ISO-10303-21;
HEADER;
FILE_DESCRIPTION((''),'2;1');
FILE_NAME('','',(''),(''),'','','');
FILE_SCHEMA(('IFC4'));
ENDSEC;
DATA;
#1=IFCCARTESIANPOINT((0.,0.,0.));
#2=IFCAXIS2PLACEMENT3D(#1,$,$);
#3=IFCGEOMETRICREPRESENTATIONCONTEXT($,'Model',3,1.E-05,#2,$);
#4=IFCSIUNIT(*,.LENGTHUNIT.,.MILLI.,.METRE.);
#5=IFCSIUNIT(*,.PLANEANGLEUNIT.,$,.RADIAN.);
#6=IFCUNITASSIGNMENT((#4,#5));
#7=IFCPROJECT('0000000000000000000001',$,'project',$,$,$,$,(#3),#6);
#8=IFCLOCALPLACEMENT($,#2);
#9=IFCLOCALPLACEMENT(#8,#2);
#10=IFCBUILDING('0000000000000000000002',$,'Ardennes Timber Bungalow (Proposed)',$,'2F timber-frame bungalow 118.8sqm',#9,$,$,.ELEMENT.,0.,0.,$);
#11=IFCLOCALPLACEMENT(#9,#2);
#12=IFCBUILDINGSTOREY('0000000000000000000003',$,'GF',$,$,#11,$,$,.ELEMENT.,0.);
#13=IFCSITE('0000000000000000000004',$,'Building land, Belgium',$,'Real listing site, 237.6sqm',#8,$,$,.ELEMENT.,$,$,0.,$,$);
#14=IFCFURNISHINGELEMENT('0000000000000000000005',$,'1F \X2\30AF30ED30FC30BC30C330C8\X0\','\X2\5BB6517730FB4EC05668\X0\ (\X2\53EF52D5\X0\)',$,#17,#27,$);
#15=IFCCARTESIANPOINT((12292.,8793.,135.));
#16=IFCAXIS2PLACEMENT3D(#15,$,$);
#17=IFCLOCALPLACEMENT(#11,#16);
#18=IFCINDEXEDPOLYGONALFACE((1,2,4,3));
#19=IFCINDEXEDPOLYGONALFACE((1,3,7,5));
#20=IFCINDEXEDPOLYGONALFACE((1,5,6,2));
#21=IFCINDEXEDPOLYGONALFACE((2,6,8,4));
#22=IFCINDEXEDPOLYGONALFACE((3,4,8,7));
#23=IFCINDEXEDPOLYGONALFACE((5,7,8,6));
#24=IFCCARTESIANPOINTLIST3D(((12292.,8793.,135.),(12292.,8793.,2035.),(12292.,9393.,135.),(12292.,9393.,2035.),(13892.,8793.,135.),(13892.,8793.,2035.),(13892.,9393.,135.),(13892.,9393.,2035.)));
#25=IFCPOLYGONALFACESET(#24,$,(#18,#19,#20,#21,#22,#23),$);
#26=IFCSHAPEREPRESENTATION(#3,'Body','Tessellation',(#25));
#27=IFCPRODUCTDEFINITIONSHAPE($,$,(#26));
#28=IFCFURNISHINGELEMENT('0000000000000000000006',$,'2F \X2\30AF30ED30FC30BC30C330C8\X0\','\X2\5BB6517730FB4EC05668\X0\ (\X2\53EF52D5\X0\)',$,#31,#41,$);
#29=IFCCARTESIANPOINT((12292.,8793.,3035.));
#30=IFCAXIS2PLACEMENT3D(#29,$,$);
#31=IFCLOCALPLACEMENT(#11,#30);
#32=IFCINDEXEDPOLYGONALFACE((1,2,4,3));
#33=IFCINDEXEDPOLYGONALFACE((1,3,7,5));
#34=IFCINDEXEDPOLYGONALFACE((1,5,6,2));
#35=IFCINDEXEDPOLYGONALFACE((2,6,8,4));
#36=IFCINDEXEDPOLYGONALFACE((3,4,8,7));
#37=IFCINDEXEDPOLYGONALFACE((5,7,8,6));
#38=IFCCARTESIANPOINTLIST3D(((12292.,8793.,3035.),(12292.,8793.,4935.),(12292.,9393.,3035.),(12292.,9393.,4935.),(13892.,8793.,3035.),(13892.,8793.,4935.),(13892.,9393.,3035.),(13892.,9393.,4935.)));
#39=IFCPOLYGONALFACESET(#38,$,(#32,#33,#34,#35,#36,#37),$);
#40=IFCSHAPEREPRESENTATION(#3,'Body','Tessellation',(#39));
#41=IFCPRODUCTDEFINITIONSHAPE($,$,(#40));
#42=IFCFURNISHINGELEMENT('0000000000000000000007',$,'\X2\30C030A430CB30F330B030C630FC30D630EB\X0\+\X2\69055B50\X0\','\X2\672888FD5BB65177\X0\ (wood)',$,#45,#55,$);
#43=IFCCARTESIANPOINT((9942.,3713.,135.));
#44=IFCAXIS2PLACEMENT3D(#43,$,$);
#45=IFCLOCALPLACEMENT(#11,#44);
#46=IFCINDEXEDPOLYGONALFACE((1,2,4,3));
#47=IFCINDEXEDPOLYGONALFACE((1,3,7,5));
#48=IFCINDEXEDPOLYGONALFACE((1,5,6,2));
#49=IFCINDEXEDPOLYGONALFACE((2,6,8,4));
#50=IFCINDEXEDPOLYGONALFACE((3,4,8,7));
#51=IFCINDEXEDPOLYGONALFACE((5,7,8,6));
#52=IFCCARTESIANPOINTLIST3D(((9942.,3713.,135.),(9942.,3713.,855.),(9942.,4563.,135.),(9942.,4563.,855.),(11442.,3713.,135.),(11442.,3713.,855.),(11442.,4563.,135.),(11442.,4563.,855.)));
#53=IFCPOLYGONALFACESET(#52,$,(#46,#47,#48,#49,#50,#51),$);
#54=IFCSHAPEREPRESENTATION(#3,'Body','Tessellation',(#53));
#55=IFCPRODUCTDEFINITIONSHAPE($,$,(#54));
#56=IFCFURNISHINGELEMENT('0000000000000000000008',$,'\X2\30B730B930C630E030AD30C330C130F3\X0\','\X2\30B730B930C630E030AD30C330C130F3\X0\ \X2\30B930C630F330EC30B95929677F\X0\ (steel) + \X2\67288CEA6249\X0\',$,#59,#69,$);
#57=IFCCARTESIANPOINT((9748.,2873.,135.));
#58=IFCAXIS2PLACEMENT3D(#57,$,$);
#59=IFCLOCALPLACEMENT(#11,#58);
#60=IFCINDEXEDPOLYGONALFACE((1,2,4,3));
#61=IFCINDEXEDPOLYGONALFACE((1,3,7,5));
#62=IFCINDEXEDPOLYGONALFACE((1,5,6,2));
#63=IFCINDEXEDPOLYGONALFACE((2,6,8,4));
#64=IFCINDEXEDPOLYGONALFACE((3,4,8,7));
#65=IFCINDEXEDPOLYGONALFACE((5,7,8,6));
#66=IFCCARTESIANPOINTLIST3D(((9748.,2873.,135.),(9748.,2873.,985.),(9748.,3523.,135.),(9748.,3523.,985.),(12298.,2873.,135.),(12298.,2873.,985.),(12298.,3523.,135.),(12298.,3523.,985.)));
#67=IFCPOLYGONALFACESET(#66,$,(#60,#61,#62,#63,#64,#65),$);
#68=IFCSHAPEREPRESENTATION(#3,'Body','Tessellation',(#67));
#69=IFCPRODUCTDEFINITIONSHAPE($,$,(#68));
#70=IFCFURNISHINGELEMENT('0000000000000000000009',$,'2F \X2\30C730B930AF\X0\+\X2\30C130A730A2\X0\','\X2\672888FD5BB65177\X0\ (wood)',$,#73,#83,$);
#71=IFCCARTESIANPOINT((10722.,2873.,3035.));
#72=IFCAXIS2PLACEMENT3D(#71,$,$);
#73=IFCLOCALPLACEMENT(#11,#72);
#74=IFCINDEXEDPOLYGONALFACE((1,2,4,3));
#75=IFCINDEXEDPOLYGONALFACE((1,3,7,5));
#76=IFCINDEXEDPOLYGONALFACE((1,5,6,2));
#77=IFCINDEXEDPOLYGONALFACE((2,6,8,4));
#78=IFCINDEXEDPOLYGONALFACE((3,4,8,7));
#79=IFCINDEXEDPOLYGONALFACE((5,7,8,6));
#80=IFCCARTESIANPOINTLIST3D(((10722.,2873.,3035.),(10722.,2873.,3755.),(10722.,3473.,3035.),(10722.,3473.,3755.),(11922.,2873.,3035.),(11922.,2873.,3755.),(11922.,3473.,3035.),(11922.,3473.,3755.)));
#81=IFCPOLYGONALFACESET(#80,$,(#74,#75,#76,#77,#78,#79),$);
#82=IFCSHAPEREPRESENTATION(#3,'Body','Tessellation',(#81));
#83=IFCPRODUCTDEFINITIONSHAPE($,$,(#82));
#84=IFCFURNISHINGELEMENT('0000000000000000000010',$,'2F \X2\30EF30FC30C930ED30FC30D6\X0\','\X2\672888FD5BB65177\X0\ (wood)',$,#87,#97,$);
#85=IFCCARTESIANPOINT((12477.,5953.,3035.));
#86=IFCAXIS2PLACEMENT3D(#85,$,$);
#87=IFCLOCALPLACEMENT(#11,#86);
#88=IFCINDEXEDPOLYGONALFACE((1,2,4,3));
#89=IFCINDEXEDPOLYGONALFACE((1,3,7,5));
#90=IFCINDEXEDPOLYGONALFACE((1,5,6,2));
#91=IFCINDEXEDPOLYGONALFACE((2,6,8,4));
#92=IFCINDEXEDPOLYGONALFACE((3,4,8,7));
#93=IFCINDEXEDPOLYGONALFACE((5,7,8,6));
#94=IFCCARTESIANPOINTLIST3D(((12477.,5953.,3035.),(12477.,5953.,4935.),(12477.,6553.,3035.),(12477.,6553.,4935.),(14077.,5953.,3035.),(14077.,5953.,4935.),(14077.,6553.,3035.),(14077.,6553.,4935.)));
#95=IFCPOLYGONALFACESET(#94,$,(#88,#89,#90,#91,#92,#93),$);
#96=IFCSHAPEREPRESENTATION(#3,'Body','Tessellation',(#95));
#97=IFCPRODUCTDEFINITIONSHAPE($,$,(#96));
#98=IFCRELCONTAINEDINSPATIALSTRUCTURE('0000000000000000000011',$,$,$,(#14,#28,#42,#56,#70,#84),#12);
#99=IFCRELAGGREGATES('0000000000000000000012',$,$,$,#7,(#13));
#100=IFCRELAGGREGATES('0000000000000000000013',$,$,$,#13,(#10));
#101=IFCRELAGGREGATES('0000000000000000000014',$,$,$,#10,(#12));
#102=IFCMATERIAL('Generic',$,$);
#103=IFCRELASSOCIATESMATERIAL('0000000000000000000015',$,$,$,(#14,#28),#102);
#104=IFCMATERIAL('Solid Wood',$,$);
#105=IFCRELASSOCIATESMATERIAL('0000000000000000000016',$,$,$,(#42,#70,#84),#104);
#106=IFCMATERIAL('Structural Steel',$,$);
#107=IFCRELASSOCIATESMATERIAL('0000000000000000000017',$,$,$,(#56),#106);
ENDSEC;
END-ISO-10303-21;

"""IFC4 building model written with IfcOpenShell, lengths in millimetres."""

from ifc_helpers import new_model, si_unit, frame, frame_2d, origin, place, context, project, spatial, rectangle, extrude, material, element, save


model = new_model("IFC4")

# Units and contexts
model_context = context("Model", 3, precision=1e-05, world=origin())
ifc_project = project(units=[si_unit("LENGTHUNIT", "METRE", prefix="MILLI"), si_unit("PLANEANGLEUNIT", "RADIAN")], contexts=[model_context])

# Site, building, storey
site_placement = place(None, origin())
site = spatial("IfcSite", under=ifc_project, at=site_placement, Name="Building land, Belgium", ObjectType="Real listing site, 237.6sqm", CompositionType="ELEMENT", RefElevation=0.0)
building_placement = place(site_placement, origin())
building = spatial("IfcBuilding", under=site, at=building_placement, Name="Ardennes Timber Bungalow (Proposed)", ObjectType="2F timber-frame bungalow 118.8sqm", CompositionType="ELEMENT", ElevationOfRefHeight=0.0, ElevationOfTerrain=0.0)
storey_placement = place(building_placement, origin())
storey = spatial("IfcBuildingStorey", under=building, at=storey_placement, Name="GF", CompositionType="ELEMENT", Elevation=0.0)

# Shared definitions
ifc_material_1 = material(Name="Solid Wood")

# Shared definitions
ifc_material_2 = material(Name="Generic")

# Furnishing elements
furnishing_1_placement = place(storey_placement, frame((12292.0, 8793.0, 135.0)))
element("IfcFurnishingElement", 1, at=furnishing_1_placement, inside=storey, material=ifc_material_2, Name="1F クローゼット", Description="家具・什器 (可動)", context=model_context, shape_type="SweptSolid", body=[
    extrude(rectangle(XDim=1600.0, YDim=600.0, at=frame_2d((800.0, 300.0))), frame((12292.0, 8793.0, 135.0)), (0.0, 0.0, 1.0), 1900.0),
])
furnishing_2_placement = place(storey_placement, frame((12292.0, 8793.0, 3035.0)))
element("IfcFurnishingElement", 2, at=furnishing_2_placement, inside=storey, material=ifc_material_2, Name="2F クローゼット", Description="家具・什器 (可動)", context=model_context, shape_type="SweptSolid", body=[
    extrude(rectangle(XDim=1600.0, YDim=600.0, at=frame_2d((800.0, 300.0))), frame((12292.0, 8793.0, 3035.0)), (0.0, 0.0, 1.0), 1900.0),
])
furnishing_3_placement = place(storey_placement, frame((9942.0, 3713.0, 135.0)))
element("IfcFurnishingElement", 3, at=furnishing_3_placement, inside=storey, material=ifc_material_1, Name="ダイニングテーブル+椅子", Description="木製家具 (wood)", context=model_context, shape_type="SweptSolid", body=[
    extrude(rectangle(XDim=1500.0, YDim=850.0, at=frame_2d((750.0, 425.0))), frame((9942.0, 3713.0, 135.0)), (0.0, 0.0, 1.0), 720.0),
])
ifc_material_3 = material(Name="Structural Steel")
furnishing_4_placement = place(storey_placement, frame((9748.0, 2873.0, 135.0)))
element("IfcFurnishingElement", 4, at=furnishing_4_placement, inside=storey, material=ifc_material_3, Name="システムキッチン", Description="システムキッチン ステンレス天板 (steel) + 木質扉", context=model_context, shape_type="SweptSolid", body=[
    extrude(rectangle(XDim=2550.0, YDim=650.0, at=frame_2d((1275.0, 325.0))), frame((9748.0, 2873.0, 135.0)), (0.0, 0.0, 1.0), 850.0),
])
furnishing_5_placement = place(storey_placement, frame((10722.0, 2873.0, 3035.0)))
element("IfcFurnishingElement", 5, at=furnishing_5_placement, inside=storey, material=ifc_material_1, Name="2F デスク+チェア", Description="木製家具 (wood)", context=model_context, shape_type="SweptSolid", body=[
    extrude(rectangle(XDim=1200.0, YDim=600.0, at=frame_2d((600.0, 300.0))), frame((10722.0, 2873.0, 3035.0)), (0.0, 0.0, 1.0), 720.0),
])
furnishing_6_placement = place(storey_placement, frame((12477.0, 5953.0, 3035.0)))
element("IfcFurnishingElement", 6, at=furnishing_6_placement, inside=storey, material=ifc_material_1, Name="2F ワードローブ", Description="木製家具 (wood)", context=model_context, shape_type="SweptSolid", body=[
    extrude(rectangle(XDim=1600.0, YDim=600.0, at=frame_2d((800.0, 300.0))), frame((12477.0, 5953.0, 3035.0)), (0.0, 0.0, 1.0), 1900.0),
])

save(model, "model.ifc")
